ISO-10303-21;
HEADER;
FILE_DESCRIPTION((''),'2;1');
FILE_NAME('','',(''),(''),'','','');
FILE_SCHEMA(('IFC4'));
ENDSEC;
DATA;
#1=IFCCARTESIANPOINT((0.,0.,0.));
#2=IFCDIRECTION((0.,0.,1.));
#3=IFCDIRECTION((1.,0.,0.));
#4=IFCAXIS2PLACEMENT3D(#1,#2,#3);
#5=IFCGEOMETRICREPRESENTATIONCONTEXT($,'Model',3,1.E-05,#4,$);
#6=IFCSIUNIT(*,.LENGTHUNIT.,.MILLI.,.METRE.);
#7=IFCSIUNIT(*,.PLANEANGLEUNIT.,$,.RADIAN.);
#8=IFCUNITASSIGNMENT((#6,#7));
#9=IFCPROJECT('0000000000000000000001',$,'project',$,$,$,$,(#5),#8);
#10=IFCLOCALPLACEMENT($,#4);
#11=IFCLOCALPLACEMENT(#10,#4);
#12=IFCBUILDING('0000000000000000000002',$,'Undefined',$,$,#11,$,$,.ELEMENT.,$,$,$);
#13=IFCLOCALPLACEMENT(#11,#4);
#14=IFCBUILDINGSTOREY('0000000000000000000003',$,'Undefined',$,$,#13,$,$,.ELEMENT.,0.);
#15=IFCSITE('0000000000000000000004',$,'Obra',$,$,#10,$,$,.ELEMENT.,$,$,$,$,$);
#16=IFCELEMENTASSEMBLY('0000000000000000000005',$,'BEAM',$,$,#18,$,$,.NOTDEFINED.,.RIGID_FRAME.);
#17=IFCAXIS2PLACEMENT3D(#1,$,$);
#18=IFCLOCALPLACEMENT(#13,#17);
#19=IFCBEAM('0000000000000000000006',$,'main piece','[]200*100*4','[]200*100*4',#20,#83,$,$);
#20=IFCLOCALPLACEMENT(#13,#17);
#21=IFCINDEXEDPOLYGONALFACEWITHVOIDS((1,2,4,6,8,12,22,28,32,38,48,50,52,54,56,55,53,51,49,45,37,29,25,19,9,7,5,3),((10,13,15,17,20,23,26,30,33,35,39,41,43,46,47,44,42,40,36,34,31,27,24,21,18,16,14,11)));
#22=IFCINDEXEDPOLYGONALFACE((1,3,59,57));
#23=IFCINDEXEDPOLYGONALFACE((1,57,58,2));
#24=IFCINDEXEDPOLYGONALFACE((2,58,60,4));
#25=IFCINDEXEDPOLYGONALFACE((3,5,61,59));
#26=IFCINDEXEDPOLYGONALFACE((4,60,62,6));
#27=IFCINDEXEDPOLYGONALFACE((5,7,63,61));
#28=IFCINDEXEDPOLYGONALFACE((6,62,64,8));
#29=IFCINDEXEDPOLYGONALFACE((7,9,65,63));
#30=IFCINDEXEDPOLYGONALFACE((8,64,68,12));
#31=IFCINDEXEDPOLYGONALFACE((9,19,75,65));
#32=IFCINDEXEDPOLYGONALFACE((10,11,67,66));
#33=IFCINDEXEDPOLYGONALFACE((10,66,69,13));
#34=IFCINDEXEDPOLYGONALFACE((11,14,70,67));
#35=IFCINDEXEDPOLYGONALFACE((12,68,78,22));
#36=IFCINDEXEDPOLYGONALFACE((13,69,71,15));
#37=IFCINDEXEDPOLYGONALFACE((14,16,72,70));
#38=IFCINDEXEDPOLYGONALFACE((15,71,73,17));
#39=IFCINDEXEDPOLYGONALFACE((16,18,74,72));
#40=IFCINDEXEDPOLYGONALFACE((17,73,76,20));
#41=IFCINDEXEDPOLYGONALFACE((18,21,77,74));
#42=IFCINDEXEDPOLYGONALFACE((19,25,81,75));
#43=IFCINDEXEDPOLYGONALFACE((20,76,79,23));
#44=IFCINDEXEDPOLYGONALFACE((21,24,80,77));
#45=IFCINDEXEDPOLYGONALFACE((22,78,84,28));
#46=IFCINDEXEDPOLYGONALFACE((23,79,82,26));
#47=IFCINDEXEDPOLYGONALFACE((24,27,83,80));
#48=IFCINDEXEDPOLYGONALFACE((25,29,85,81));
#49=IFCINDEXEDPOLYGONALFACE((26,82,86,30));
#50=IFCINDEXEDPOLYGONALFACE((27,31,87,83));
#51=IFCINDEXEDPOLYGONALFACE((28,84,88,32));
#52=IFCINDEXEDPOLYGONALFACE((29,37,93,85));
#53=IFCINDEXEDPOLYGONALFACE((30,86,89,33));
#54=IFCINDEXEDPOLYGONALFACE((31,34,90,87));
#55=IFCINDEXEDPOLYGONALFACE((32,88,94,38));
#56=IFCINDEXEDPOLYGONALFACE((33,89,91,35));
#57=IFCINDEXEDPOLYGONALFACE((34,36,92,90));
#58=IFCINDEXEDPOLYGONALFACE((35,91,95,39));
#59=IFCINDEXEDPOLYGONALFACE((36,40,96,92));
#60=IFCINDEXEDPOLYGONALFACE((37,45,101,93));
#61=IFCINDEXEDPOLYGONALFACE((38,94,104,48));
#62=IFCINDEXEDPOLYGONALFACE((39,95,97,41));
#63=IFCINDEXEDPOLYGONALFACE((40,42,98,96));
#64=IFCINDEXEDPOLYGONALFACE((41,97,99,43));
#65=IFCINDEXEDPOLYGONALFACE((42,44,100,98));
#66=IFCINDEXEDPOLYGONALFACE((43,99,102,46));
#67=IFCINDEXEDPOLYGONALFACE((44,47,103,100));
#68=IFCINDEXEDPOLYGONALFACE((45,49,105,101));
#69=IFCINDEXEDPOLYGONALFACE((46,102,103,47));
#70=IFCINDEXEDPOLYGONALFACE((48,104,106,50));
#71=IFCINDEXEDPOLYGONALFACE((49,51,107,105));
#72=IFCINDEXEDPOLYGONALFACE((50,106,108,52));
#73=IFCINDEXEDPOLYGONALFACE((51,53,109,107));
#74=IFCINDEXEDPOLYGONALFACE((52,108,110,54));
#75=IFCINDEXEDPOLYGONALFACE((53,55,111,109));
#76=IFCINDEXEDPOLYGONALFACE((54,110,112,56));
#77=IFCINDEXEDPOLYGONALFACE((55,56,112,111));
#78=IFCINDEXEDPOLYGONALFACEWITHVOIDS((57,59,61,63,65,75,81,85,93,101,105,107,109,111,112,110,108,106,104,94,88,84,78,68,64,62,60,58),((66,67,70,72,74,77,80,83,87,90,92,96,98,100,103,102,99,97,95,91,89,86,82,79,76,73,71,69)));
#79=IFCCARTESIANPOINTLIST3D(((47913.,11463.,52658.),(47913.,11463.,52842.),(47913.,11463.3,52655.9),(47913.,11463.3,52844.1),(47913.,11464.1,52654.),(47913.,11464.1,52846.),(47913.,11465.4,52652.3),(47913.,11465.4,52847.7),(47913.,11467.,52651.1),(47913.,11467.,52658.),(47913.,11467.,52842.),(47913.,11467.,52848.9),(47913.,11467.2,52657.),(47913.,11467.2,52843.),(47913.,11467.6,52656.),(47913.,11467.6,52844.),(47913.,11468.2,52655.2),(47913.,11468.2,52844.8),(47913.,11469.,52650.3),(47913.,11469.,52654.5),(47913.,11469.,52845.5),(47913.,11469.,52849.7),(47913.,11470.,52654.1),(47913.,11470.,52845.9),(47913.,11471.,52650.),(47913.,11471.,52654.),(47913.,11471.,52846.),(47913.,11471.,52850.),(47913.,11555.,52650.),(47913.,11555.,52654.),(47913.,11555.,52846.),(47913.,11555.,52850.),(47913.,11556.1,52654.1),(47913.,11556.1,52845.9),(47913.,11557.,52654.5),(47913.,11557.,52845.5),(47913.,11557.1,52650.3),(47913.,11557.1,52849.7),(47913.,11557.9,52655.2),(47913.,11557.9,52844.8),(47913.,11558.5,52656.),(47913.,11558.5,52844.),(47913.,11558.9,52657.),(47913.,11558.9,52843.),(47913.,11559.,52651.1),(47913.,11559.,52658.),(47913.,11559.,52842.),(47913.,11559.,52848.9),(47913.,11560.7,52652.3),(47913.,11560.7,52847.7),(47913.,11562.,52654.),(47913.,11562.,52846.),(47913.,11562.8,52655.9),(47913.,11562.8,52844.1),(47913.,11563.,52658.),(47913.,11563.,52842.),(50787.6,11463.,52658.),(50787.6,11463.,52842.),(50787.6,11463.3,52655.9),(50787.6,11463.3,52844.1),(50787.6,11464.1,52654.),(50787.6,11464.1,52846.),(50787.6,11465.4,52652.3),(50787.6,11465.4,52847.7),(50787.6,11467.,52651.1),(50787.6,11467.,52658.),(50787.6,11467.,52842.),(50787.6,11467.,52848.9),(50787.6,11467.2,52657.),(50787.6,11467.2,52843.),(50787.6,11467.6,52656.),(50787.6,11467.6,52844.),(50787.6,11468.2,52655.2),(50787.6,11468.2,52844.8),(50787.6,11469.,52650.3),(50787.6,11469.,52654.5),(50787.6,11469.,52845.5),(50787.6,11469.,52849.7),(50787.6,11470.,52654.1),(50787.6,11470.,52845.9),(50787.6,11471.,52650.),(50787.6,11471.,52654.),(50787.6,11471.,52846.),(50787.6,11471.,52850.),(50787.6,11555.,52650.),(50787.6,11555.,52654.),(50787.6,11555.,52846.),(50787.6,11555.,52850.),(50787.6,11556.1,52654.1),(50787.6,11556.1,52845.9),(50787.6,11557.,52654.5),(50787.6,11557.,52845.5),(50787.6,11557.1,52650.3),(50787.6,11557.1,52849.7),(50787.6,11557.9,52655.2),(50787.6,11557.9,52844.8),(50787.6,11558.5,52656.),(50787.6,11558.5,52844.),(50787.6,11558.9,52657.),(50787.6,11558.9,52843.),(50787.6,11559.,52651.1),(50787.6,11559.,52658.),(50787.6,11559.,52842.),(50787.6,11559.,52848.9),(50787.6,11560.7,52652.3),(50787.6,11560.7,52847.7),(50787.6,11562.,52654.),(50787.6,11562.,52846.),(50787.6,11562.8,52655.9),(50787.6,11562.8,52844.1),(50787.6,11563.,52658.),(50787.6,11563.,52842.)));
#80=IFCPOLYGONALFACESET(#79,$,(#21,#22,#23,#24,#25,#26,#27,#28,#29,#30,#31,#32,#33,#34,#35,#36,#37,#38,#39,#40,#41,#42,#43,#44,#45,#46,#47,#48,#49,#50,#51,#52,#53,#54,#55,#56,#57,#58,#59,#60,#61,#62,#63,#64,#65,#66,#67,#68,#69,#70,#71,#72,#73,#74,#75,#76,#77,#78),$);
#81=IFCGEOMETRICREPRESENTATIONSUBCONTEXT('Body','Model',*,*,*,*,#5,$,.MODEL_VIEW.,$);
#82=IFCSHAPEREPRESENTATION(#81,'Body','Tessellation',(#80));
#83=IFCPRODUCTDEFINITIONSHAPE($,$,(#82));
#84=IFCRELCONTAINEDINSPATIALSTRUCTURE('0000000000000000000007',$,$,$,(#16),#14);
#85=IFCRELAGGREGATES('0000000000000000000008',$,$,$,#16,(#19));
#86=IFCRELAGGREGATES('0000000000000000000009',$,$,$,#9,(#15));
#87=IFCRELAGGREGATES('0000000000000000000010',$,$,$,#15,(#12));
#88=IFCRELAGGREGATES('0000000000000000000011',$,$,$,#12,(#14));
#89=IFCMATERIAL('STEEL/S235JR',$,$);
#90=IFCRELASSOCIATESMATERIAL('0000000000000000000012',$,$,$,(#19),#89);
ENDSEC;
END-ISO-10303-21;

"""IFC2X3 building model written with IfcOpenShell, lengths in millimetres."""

from ifc_helpers import new_model, si_unit, frame, origin_with_axes, origin_2d_with_axis, place, context, subcontext, project, spatial, hollow_rectangle, extrude, material, element, aggregate, save


model = new_model("IFC2X3")

# Units and contexts
model_context = context("Model", 3, precision=1e-05, world=origin_with_axes())
body_context = subcontext(model_context, "Body", "Model", "MODEL_VIEW")
ifc_project = project(units=[si_unit("LENGTHUNIT", "METRE", prefix="MILLI"), si_unit("PLANEANGLEUNIT", "RADIAN")], contexts=[model_context])

# Site, building, storey
site_placement = place(None, origin_with_axes())
site = spatial("IfcSite", under=ifc_project, at=site_placement, Name="Obra", CompositionType="ELEMENT")
building_placement = place(site_placement, origin_with_axes())
building = spatial("IfcBuilding", under=site, at=building_placement, Name="Undefined", CompositionType="ELEMENT")
storey_placement = place(building_placement, origin_with_axes())
storey = spatial("IfcBuildingStorey", under=building, at=storey_placement, Name="Undefined", CompositionType="ELEMENT", Elevation=0.0)

# Shared definitions
ifc_material_1 = material(Name="STEEL/S235JR")

# Element assembly, beam
assembly_1_placement = place(storey_placement, origin_with_axes())
assembly_1 = element("IfcElementAssembly", 1, at=assembly_1_placement, inside=storey, Name="BEAM", AssemblyPlace="NOTDEFINED", PredefinedType="RIGID_FRAME")
beam_1_placement = place(assembly_1_placement, frame((47913.0, 11513.0, 52750.0), z_axis=(0.0, 0.0, 1.0), x_axis=(1.0, 0.0, 0.0)))
beam_1 = element("IfcBeam", 2, at=beam_1_placement, material=ifc_material_1, Name="main piece", Description="[]200*100*4", ObjectType="[]200*100*4", context=body_context, shape_type="SweptSolid", body=[
    extrude(hollow_rectangle(XDim=100.0, YDim=200.0, WallThickness=4.0, InnerFilletRadius=4.0, OuterFilletRadius=8.0, at=origin_2d_with_axis()), frame((2874.6, 0.0, 0.0), z_axis=(-1.0, 0.0, 0.0), x_axis=(0.0, -1.0, 0.0)), (0.0, 0.0, 1.0), 2874.6),
])
aggregate(assembly_1, [beam_1])

save(model, "model.ifc")
